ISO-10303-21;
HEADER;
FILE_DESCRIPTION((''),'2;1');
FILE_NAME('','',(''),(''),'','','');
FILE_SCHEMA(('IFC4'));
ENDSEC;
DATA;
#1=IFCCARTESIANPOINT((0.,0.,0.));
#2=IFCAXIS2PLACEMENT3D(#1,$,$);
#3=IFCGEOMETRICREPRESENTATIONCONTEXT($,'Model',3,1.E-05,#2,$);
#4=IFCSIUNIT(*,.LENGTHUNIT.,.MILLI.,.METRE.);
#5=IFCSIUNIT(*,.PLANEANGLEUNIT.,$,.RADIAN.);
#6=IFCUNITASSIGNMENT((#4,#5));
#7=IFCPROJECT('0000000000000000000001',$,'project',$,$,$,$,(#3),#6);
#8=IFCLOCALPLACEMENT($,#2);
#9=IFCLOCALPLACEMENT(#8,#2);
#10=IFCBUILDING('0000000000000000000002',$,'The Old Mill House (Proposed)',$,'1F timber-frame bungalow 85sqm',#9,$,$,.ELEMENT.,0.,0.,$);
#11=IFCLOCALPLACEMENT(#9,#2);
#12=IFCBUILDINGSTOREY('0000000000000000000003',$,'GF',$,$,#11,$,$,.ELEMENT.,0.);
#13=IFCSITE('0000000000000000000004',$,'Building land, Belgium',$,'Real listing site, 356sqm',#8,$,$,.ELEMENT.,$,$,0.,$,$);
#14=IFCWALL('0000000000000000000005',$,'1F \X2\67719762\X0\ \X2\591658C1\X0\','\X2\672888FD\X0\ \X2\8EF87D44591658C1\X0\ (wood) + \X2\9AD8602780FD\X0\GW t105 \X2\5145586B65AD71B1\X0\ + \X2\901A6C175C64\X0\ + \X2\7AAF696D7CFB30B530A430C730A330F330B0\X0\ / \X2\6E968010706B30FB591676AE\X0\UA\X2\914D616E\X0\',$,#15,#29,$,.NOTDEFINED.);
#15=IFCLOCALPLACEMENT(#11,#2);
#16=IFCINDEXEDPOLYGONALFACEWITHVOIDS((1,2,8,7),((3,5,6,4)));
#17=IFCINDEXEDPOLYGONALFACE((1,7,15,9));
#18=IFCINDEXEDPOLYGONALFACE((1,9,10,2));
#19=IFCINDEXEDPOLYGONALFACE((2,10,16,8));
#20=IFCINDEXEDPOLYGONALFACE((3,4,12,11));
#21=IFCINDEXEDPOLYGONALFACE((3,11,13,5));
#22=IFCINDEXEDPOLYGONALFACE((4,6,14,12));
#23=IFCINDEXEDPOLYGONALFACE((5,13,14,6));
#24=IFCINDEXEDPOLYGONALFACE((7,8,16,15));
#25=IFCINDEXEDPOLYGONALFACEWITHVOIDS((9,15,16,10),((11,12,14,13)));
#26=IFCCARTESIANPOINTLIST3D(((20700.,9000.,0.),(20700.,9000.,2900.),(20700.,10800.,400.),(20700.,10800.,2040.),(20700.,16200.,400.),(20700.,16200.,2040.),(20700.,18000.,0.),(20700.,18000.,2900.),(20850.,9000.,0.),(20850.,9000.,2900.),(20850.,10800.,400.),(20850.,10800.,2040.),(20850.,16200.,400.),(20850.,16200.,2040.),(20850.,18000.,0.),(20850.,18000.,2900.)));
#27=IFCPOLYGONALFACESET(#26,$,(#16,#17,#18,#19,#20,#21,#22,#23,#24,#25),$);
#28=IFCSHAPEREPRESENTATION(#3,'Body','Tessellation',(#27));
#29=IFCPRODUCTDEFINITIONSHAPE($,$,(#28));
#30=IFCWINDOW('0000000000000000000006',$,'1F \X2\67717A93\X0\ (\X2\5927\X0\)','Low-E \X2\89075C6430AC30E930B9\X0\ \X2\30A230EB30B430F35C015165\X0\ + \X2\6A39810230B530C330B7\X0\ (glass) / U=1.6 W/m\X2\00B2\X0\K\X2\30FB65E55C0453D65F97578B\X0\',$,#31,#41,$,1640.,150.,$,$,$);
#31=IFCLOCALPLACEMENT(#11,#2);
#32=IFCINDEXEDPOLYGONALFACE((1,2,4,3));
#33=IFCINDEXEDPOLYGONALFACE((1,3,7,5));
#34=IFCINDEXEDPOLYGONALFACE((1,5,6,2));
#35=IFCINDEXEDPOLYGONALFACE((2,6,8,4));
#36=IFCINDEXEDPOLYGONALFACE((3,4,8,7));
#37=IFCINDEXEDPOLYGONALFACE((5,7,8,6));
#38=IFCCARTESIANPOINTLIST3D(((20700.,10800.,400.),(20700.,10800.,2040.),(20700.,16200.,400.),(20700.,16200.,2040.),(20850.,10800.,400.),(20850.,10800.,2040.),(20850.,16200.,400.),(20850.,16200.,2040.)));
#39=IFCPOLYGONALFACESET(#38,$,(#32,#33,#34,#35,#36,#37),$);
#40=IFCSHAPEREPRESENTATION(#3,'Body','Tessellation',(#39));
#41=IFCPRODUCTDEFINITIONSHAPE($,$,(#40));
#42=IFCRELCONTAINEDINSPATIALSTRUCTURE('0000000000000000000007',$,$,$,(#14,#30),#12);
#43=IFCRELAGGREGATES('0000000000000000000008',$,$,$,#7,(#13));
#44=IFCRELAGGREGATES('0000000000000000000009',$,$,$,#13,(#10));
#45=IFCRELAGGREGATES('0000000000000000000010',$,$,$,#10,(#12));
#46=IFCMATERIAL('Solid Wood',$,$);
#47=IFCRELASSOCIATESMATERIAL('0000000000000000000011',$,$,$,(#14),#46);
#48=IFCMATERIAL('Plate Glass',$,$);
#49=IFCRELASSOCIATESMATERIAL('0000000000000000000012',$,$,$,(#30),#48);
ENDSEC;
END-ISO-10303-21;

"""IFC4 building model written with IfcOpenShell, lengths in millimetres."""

from ifc_helpers import new_model, si_unit, frame, frame_2d, origin, place, context, project, spatial, rectangle, extrude, material, element, fill, save


model = new_model("IFC4")

# Units and contexts
model_context = context("Model", 3, precision=1e-05, world=origin())
ifc_project = project(units=[si_unit("LENGTHUNIT", "METRE", prefix="MILLI"), si_unit("PLANEANGLEUNIT", "RADIAN")], contexts=[model_context])

# Site, building, storey
site_placement = place(None, origin())
site = spatial("IfcSite", under=ifc_project, at=site_placement, Name="Building land, Belgium", ObjectType="Real listing site, 356sqm", CompositionType="ELEMENT", RefElevation=0.0)
building_placement = place(site_placement, origin())
building = spatial("IfcBuilding", under=site, at=building_placement, Name="The Old Mill House (Proposed)", ObjectType="1F timber-frame bungalow 85sqm", CompositionType="ELEMENT", ElevationOfRefHeight=0.0, ElevationOfTerrain=0.0)
storey_placement = place(building_placement, origin())
storey = spatial("IfcBuildingStorey", under=building, at=storey_placement, Name="GF", CompositionType="ELEMENT", Elevation=0.0)

# Shared definitions
ifc_material_1 = material(Name="Solid Wood")

# Wall, opening, window
wall_1_placement = place(storey_placement, frame((10350.0, 4500.0, 0.0)))
wall_1 = element("IfcWall", 1, at=wall_1_placement, inside=storey, material=ifc_material_1, Name="1F 東面 外壁", Description="木製 軸組外壁 (wood) + 高性能GW t105 充填断熱 + 通気層 + 窯業系サイディング / 準耐火・外皮UA配慮", PredefinedType="NOTDEFINED", context=model_context, shape_type="SweptSolid", body=[
    extrude(rectangle(XDim=150.0, YDim=9000.0, at=frame_2d((75.0, 4500.0))), frame((10350.0, 4500.0, 0.0)), (0.0, 0.0, 1.0), 2900.0),
])
opening_1_placement = place(storey_placement, frame((10350.0, 5400.0, 200.0)))
opening_1 = element("IfcOpeningElement", 2, at=opening_1_placement, cuts=wall_1, PredefinedType="NOTDEFINED", context=model_context, shape_type="SweptSolid", body=[
    extrude(rectangle(XDim=150.0, YDim=5400.0, at=frame_2d((75.0, 2700.0))), frame((10350.0, 5400.0, 200.0)), (0.0, 0.0, 1.0), 1640.0),
])
ifc_material_2 = material(Name="Plate Glass")
window_1_placement = place(storey_placement, frame((10350.0, 5400.0, 200.0)))
window_1 = element("IfcWindow", 3, at=window_1_placement, inside=storey, material=ifc_material_2, Name="1F 東窓 (大)", Description="Low-E 複層ガラス アルゴン封入 + 樹脂サッシ (glass) / U=1.6 W/m²K・日射取得型", OverallHeight=1640.0, OverallWidth=150.0, context=model_context, shape_type="SweptSolid", body=[
    extrude(rectangle(XDim=150.0, YDim=5400.0, at=frame_2d((75.0, 2700.0))), frame((10350.0, 5400.0, 200.0)), (0.0, 0.0, 1.0), 1640.0),
])
fill(opening_1, window_1)

save(model, "model.ifc")
